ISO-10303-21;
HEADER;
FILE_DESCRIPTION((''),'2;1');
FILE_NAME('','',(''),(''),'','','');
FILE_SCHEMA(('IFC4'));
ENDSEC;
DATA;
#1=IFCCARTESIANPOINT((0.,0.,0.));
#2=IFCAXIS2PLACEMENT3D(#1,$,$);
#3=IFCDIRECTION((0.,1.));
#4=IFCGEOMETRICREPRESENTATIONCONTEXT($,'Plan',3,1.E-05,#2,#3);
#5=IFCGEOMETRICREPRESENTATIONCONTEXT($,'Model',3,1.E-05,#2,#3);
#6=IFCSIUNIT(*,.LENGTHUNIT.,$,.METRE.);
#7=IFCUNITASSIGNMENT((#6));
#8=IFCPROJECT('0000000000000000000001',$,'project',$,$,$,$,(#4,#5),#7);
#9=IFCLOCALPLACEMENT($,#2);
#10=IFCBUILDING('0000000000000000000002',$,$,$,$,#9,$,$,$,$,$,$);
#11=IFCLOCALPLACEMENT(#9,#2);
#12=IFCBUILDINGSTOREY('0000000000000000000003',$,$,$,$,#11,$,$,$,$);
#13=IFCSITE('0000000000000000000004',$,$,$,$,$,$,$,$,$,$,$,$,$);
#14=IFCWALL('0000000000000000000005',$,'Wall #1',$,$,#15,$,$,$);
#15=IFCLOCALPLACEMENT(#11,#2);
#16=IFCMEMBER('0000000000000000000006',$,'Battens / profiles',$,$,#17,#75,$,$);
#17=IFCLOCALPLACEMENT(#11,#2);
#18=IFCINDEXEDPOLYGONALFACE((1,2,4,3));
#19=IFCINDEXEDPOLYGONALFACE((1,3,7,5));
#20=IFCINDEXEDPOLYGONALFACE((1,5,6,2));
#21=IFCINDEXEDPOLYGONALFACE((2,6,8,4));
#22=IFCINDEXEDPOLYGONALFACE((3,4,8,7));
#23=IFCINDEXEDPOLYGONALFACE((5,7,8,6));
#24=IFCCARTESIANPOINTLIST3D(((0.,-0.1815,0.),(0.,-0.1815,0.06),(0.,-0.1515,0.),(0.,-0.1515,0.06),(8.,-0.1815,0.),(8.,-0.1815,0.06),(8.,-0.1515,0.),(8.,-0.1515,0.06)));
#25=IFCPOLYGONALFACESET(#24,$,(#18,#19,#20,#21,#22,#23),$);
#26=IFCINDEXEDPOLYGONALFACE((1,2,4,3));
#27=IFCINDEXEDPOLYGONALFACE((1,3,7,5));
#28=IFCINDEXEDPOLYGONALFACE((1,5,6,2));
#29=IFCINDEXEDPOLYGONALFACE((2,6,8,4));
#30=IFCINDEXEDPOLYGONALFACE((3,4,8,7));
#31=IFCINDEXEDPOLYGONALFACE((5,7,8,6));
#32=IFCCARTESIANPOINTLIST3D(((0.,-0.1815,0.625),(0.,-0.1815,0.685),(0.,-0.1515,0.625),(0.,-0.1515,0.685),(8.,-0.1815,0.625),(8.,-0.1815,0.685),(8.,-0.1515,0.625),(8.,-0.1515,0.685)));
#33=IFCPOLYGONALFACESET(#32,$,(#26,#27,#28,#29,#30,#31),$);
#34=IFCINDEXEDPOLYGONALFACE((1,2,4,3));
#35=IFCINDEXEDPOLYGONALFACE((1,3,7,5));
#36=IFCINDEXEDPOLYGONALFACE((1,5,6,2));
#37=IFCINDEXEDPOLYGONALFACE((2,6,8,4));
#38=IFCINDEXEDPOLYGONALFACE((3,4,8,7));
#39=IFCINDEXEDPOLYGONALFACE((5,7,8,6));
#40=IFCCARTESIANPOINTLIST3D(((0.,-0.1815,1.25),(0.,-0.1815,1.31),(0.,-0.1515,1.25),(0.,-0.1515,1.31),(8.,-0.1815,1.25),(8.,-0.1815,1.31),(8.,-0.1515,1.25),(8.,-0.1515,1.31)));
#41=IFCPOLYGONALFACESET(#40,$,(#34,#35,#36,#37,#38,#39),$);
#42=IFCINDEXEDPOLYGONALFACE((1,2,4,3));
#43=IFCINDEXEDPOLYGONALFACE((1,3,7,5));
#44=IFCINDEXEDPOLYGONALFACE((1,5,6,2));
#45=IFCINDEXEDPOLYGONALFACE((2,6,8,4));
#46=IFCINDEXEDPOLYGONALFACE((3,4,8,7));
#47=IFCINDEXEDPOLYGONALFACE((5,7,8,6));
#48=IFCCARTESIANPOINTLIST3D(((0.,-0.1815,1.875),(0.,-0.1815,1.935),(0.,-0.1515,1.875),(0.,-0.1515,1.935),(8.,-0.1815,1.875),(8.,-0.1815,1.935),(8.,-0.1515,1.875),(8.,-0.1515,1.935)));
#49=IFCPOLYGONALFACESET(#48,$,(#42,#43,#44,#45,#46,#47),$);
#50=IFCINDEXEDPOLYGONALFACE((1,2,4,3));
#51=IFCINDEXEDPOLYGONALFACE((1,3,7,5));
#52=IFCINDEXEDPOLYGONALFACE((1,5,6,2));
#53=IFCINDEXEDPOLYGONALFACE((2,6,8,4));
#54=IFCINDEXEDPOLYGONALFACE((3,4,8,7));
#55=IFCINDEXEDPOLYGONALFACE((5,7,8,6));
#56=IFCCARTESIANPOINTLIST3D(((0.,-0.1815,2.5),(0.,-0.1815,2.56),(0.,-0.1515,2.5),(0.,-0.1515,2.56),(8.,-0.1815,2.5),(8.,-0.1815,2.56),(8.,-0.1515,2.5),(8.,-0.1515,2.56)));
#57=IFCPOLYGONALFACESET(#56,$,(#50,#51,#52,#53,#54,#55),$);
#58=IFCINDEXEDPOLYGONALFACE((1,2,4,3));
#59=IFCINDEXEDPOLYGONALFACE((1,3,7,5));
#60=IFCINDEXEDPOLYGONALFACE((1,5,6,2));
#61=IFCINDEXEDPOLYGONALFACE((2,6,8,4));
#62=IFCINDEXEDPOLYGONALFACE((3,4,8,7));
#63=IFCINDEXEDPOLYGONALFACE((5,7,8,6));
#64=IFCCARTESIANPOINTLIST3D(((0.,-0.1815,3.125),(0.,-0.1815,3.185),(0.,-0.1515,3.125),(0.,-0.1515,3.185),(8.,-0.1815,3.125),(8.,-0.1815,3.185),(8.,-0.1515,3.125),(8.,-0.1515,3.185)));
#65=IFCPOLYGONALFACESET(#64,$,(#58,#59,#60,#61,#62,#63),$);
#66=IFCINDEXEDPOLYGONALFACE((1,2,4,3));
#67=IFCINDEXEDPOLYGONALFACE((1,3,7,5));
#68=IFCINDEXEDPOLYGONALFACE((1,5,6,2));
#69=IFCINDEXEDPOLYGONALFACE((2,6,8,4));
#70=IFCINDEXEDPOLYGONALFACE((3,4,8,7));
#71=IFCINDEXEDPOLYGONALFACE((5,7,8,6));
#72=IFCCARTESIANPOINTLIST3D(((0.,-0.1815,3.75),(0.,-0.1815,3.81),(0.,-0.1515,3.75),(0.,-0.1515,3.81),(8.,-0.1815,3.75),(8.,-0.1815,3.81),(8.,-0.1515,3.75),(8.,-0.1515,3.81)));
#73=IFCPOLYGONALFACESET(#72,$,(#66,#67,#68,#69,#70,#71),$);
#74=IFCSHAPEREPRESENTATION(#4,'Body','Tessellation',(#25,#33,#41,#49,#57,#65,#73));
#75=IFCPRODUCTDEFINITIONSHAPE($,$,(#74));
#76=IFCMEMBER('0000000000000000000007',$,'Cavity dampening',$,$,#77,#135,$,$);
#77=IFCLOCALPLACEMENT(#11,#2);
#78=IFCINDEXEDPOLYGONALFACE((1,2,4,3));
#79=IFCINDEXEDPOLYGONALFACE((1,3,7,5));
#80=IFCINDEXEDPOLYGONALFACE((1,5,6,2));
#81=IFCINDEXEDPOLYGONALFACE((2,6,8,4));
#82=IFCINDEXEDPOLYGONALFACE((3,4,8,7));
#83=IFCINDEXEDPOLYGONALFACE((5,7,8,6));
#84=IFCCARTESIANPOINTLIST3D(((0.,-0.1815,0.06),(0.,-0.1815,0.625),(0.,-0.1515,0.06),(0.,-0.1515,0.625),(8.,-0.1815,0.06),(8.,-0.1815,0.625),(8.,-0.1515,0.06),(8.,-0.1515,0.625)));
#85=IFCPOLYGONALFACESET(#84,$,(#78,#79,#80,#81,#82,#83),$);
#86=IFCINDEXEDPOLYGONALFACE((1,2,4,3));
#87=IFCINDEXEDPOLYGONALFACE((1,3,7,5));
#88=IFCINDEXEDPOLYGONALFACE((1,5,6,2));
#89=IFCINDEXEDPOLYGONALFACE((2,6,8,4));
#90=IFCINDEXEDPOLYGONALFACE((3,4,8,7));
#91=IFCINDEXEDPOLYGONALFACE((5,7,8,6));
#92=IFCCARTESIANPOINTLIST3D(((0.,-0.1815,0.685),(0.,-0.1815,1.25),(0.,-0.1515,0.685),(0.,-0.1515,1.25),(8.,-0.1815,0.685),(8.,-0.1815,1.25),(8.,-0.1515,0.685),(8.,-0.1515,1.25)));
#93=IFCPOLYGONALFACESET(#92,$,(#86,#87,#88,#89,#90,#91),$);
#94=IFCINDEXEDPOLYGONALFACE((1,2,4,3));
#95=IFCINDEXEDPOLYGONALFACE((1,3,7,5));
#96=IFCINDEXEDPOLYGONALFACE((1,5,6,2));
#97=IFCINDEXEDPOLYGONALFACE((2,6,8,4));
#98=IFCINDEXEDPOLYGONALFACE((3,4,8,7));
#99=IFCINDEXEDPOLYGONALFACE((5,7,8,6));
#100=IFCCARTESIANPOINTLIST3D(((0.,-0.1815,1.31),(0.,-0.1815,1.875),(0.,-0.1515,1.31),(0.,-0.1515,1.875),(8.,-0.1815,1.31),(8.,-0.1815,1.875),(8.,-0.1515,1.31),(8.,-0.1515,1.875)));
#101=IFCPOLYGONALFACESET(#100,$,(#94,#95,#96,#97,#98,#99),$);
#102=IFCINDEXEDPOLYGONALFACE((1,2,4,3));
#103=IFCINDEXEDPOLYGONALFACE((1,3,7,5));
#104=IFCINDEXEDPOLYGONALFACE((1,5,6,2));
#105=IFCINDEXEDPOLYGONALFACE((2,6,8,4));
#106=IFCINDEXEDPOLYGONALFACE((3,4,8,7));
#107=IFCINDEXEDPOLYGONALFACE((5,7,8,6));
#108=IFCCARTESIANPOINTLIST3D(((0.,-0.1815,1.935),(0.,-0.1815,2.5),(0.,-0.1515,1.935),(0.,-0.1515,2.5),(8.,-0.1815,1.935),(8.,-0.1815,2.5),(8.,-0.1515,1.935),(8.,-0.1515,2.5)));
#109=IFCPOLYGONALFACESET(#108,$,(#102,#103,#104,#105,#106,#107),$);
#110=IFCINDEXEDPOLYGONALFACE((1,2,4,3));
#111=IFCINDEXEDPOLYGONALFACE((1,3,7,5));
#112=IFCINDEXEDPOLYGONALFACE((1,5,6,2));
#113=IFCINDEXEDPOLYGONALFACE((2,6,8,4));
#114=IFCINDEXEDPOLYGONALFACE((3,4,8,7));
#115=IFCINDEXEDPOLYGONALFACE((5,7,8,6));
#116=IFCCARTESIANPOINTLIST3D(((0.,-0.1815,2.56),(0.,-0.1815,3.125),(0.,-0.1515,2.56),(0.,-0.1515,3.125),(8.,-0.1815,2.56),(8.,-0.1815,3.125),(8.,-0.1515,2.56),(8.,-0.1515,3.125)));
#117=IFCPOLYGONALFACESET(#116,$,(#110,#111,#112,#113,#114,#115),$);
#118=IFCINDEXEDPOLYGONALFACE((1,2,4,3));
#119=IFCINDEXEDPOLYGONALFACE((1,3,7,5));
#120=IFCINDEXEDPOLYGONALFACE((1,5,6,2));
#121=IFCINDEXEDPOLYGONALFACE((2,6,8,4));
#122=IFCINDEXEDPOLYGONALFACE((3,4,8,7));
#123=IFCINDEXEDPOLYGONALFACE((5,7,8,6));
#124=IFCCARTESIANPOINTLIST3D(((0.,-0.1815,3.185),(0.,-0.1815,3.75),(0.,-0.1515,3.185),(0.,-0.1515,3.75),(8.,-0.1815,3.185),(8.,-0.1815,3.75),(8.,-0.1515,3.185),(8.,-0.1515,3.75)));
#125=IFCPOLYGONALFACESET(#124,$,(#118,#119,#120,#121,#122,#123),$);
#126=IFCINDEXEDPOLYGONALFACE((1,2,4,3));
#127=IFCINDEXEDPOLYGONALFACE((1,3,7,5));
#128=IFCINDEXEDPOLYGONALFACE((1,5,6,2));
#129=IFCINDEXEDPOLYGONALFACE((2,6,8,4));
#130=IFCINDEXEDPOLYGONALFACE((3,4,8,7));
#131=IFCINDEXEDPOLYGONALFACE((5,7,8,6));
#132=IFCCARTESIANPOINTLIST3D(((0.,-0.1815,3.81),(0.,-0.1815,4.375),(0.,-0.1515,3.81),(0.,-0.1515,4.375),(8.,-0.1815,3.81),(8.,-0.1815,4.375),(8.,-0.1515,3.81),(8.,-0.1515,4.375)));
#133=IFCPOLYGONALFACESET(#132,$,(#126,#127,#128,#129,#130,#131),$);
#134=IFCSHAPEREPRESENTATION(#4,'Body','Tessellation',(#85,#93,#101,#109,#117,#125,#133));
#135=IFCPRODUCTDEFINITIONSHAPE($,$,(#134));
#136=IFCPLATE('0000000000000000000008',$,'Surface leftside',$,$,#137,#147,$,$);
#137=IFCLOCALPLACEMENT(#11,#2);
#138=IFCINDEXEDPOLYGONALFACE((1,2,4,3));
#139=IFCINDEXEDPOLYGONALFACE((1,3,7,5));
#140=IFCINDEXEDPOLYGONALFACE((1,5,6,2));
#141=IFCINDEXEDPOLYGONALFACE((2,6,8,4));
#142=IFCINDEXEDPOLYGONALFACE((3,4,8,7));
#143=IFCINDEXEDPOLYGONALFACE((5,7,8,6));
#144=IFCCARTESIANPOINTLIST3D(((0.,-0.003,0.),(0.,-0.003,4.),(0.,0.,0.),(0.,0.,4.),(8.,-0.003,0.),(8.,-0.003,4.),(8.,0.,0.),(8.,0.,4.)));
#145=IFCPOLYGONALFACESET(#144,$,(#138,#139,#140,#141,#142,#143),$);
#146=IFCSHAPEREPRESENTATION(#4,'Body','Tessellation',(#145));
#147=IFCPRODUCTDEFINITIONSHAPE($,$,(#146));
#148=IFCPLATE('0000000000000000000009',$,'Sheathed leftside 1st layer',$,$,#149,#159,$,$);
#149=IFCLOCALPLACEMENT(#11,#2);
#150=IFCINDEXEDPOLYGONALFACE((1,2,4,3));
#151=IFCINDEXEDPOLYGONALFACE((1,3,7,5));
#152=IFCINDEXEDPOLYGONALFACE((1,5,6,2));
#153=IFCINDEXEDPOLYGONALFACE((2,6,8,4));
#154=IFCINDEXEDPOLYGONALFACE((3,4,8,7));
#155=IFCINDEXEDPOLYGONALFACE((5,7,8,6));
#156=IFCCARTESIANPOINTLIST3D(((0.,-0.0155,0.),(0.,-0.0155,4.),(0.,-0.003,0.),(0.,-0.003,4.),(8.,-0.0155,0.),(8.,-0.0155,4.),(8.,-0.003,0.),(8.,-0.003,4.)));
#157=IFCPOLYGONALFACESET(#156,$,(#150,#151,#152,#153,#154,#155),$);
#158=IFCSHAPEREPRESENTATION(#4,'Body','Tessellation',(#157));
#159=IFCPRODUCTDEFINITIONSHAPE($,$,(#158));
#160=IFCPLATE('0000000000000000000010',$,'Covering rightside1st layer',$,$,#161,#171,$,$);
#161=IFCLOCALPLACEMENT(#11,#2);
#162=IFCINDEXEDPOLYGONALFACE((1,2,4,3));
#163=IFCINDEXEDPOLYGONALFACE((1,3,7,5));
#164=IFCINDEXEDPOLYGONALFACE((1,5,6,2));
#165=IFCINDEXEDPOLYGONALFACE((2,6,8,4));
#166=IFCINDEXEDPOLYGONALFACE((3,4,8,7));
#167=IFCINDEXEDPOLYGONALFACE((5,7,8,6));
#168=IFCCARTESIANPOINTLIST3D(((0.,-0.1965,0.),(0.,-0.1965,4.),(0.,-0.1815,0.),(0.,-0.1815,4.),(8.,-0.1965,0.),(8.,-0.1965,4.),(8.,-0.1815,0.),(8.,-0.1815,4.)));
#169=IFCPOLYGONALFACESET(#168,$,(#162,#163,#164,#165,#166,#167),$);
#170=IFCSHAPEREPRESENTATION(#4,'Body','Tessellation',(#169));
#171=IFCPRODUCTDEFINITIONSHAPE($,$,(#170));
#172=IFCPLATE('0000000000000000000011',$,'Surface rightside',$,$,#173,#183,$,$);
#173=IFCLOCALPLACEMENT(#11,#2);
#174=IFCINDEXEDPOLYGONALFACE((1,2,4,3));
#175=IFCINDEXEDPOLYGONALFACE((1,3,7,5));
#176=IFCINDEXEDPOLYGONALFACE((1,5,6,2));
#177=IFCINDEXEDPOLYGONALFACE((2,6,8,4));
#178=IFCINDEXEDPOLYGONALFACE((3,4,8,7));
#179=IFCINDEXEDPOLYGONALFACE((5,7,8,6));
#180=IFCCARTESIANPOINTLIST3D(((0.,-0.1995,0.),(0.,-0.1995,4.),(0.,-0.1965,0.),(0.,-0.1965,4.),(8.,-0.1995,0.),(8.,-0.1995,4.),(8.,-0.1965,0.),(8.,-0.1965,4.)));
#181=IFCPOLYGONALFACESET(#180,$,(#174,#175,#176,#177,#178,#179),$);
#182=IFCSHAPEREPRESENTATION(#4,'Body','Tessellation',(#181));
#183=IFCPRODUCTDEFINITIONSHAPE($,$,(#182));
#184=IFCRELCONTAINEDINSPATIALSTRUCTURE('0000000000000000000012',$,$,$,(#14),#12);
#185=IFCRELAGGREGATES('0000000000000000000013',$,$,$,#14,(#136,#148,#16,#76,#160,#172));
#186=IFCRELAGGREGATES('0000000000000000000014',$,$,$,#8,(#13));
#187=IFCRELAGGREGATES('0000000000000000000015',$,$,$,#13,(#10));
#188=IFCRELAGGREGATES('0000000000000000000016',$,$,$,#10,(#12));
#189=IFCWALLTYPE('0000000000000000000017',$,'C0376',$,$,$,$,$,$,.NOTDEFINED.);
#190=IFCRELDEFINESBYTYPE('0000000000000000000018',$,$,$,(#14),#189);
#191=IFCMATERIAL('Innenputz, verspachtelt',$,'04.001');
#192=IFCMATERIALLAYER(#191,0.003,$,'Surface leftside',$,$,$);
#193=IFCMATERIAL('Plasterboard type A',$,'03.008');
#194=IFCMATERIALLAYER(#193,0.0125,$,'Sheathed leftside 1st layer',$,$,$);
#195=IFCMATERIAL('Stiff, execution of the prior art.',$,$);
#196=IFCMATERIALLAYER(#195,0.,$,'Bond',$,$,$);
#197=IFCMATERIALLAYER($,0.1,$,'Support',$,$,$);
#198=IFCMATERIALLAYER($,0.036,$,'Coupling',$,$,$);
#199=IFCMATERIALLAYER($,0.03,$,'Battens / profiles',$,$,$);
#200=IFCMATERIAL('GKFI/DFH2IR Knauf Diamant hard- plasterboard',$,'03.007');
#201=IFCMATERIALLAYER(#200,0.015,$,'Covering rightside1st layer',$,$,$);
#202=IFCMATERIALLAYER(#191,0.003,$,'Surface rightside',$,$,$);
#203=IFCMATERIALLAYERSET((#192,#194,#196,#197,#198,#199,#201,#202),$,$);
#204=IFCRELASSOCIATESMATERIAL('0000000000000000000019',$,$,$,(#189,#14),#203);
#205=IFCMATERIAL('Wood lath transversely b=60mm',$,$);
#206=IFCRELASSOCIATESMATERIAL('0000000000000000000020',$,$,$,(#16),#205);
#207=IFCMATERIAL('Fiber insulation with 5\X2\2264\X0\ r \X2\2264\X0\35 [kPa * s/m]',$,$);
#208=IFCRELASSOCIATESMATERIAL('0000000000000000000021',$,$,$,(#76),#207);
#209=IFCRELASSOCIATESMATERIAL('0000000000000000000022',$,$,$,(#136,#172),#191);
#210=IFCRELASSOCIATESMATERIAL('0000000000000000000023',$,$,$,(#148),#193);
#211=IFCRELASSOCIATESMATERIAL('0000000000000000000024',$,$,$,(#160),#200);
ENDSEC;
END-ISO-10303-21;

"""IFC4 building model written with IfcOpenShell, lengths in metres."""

from ifc_helpers import new_model, si_unit, direction, frame, frame_2d, origin, origin_with_axes, place, context, project, spatial, rectangle, extrude, material, layer, layer_set, type_object, element, aggregate, save


model = new_model("IFC4")

# Units and contexts
plan_context = context("Plan", 3, precision=1e-05, world=origin(), true_north=direction((0.0, 1.0)))
model_context = context("Model", 3, precision=1e-05, world=origin(), true_north=direction((0.0, 1.0)))
ifc_project = project(units=[si_unit("LENGTHUNIT", "METRE")], contexts=[plan_context, model_context])

# Site, building, storey
site = spatial("IfcSite", under=ifc_project)
building_placement = place(None, origin())
building = spatial("IfcBuilding", under=site, at=building_placement)
storey_placement = place(building_placement, origin())
storey = spatial("IfcBuildingStorey", under=building, at=storey_placement)

# Wall, members, plates
ifc_material_1 = material(Name="Innenputz, verspachtelt", Category="04.001")
ifc_layer_1 = layer(ifc_material_1, 0.003, Name="Surface leftside")
ifc_material_2 = material(Name="Plasterboard type A", Category="03.008")
ifc_layer_2 = layer(ifc_material_2, 0.0125, Name="Sheathed leftside 1st layer")
ifc_material_3 = material(Name="Stiff, execution of the prior art.")
ifc_layer_3 = layer(ifc_material_3, 0.0, Name="Bond")
ifc_layer_4 = layer(None, 0.1, Name="Support")
ifc_layer_5 = layer(None, 0.036, Name="Coupling")
ifc_layer_6 = layer(None, 0.03, Name="Battens / profiles")
ifc_material_4 = material(Name="GKFI/DFH2IR Knauf Diamant hard- plasterboard", Category="03.007")
ifc_layer_7 = layer(ifc_material_4, 0.015, Name="Covering rightside1st layer")
ifc_layer_8 = layer(ifc_material_1, 0.003, Name="Surface rightside")
ifc_layer_set = layer_set([ifc_layer_1, ifc_layer_2, ifc_layer_3, ifc_layer_4, ifc_layer_5, ifc_layer_6, ifc_layer_7, ifc_layer_8])
wall_type = type_object("IfcWallType", Name="C0376", PredefinedType="NOTDEFINED", material=ifc_layer_set)
wall_placement = place(None, frame((0.0, 0.0, 0.0), z_axis=(0.0, -1.0, 0.0), x_axis=(1.0, 0.0, 0.0)))
wall = element("IfcWall", 1, at=wall_placement, inside=storey, type_object=wall_type, material=ifc_layer_set, Name="Wall #1")
ifc_material_5 = material(Name="Wood lath transversely b=60mm")
member_1_placement = place(wall_placement, origin())
member_1 = element("IfcMember", 2, at=member_1_placement, material=ifc_material_5, Name="Battens / profiles", context=plan_context, shape_type="SweptSolid", body=[
    extrude(rectangle(XDim=0.06, YDim=0.03, at=frame_2d((0.03, 0.015), x_axis=(1.0, 0.0))), frame((0.0, 0.0, 0.1515), z_axis=(1.0, 0.0, 0.0), x_axis=(0.0, 1.0, 0.0)), (0.0, 0.0, 1.0), 8.0),
    extrude(rectangle(XDim=0.06, YDim=0.03, at=frame_2d((0.03, 0.015), x_axis=(1.0, 0.0))), frame((0.0, 0.625, 0.1515), z_axis=(1.0, 0.0, 0.0), x_axis=(0.0, 1.0, 0.0)), (0.0, 0.0, 1.0), 8.0),
    extrude(rectangle(XDim=0.06, YDim=0.03, at=frame_2d((0.03, 0.015), x_axis=(1.0, 0.0))), frame((0.0, 1.25, 0.1515), z_axis=(1.0, 0.0, 0.0), x_axis=(0.0, 1.0, 0.0)), (0.0, 0.0, 1.0), 8.0),
    extrude(rectangle(XDim=0.06, YDim=0.03, at=frame_2d((0.03, 0.015), x_axis=(1.0, 0.0))), frame((0.0, 1.875, 0.1515), z_axis=(1.0, 0.0, 0.0), x_axis=(0.0, 1.0, 0.0)), (0.0, 0.0, 1.0), 8.0),
    extrude(rectangle(XDim=0.06, YDim=0.03, at=frame_2d((0.03, 0.015), x_axis=(1.0, 0.0))), frame((0.0, 2.5, 0.1515), z_axis=(1.0, 0.0, 0.0), x_axis=(0.0, 1.0, 0.0)), (0.0, 0.0, 1.0), 8.0),
    extrude(rectangle(XDim=0.06, YDim=0.03, at=frame_2d((0.03, 0.015), x_axis=(1.0, 0.0))), frame((0.0, 3.125, 0.1515), z_axis=(1.0, 0.0, 0.0), x_axis=(0.0, 1.0, 0.0)), (0.0, 0.0, 1.0), 8.0),
    extrude(rectangle(XDim=0.06, YDim=0.03, at=frame_2d((0.03, 0.015), x_axis=(1.0, 0.0))), frame((0.0, 3.75, 0.1515), z_axis=(1.0, 0.0, 0.0), x_axis=(0.0, 1.0, 0.0)), (0.0, 0.0, 1.0), 8.0),
])
ifc_material_6 = material(Name="Fiber insulation with 5≤ r ≤35 [kPa * s/m]")
member_2_placement = place(wall_placement, origin())
member_2 = element("IfcMember", 3, at=member_2_placement, material=ifc_material_6, Name="Cavity dampening", context=plan_context, shape_type="SweptSolid", body=[
    extrude(rectangle(XDim=0.565, YDim=0.03, at=frame_2d((0.2825, 0.015), x_axis=(1.0, 0.0))), frame((0.0, 0.06, 0.1515), z_axis=(1.0, 0.0, 0.0), x_axis=(0.0, 1.0, 0.0)), (0.0, 0.0, 1.0), 8.0),
    extrude(rectangle(XDim=0.565, YDim=0.03, at=frame_2d((0.2825, 0.015), x_axis=(1.0, 0.0))), frame((0.0, 0.685, 0.1515), z_axis=(1.0, 0.0, 0.0), x_axis=(0.0, 1.0, 0.0)), (0.0, 0.0, 1.0), 8.0),
    extrude(rectangle(XDim=0.565, YDim=0.03, at=frame_2d((0.2825, 0.015), x_axis=(1.0, 0.0))), frame((0.0, 1.31, 0.1515), z_axis=(1.0, 0.0, 0.0), x_axis=(0.0, 1.0, 0.0)), (0.0, 0.0, 1.0), 8.0),
    extrude(rectangle(XDim=0.565, YDim=0.03, at=frame_2d((0.2825, 0.015), x_axis=(1.0, 0.0))), frame((0.0, 1.935, 0.1515), z_axis=(1.0, 0.0, 0.0), x_axis=(0.0, 1.0, 0.0)), (0.0, 0.0, 1.0), 8.0),
    extrude(rectangle(XDim=0.565, YDim=0.03, at=frame_2d((0.2825, 0.015), x_axis=(1.0, 0.0))), frame((0.0, 2.56, 0.1515), z_axis=(1.0, 0.0, 0.0), x_axis=(0.0, 1.0, 0.0)), (0.0, 0.0, 1.0), 8.0),
    extrude(rectangle(XDim=0.565, YDim=0.03, at=frame_2d((0.2825, 0.015), x_axis=(1.0, 0.0))), frame((0.0, 3.185, 0.1515), z_axis=(1.0, 0.0, 0.0), x_axis=(0.0, 1.0, 0.0)), (0.0, 0.0, 1.0), 8.0),
    extrude(rectangle(XDim=0.565, YDim=0.03, at=frame_2d((0.2825, 0.015), x_axis=(1.0, 0.0))), frame((0.0, 3.81, 0.1515), z_axis=(1.0, 0.0, 0.0), x_axis=(0.0, 1.0, 0.0)), (0.0, 0.0, 1.0), 8.0),
])
plate_1_placement = place(wall_placement, origin())
plate_1 = element("IfcPlate", 4, at=plate_1_placement, material=ifc_material_1, Name="Surface leftside", context=plan_context, shape_type="SweptSolid", body=[
    extrude(rectangle(XDim=8.0, YDim=4.0, at=frame_2d((4.0, 2.0), x_axis=(1.0, 0.0))), origin_with_axes(), (0.0, 0.0, 1.0), 0.003),
])
plate_2_placement = place(wall_placement, origin())
plate_2 = element("IfcPlate", 5, at=plate_2_placement, material=ifc_material_2, Name="Sheathed leftside 1st layer", context=plan_context, shape_type="SweptSolid", body=[
    extrude(rectangle(XDim=8.0, YDim=4.0, at=frame_2d((4.0, 2.0), x_axis=(1.0, 0.0))), frame((0.0, 0.0, 0.003), z_axis=(0.0, 0.0, 1.0), x_axis=(1.0, 0.0, 0.0)), (0.0, 0.0, 1.0), 0.0125),
])
plate_3_placement = place(wall_placement, origin())
plate_3 = element("IfcPlate", 6, at=plate_3_placement, material=ifc_material_4, Name="Covering rightside1st layer", context=plan_context, shape_type="SweptSolid", body=[
    extrude(rectangle(XDim=8.0, YDim=4.0, at=frame_2d((4.0, 2.0), x_axis=(1.0, 0.0))), frame((0.0, 0.0, 0.1815), z_axis=(0.0, 0.0, 1.0), x_axis=(1.0, 0.0, 0.0)), (0.0, 0.0, 1.0), 0.015),
])
plate_4_placement = place(wall_placement, origin())
plate_4 = element("IfcPlate", 7, at=plate_4_placement, material=ifc_material_1, Name="Surface rightside", context=plan_context, shape_type="SweptSolid", body=[
    extrude(rectangle(XDim=8.0, YDim=4.0, at=frame_2d((4.0, 2.0), x_axis=(1.0, 0.0))), frame((0.0, 0.0, 0.1965), z_axis=(0.0, 0.0, 1.0), x_axis=(1.0, 0.0, 0.0)), (0.0, 0.0, 1.0), 0.003),
])
aggregate(wall, [plate_1, plate_2, member_1, member_2, plate_3, plate_4])

save(model, "model.ifc")
